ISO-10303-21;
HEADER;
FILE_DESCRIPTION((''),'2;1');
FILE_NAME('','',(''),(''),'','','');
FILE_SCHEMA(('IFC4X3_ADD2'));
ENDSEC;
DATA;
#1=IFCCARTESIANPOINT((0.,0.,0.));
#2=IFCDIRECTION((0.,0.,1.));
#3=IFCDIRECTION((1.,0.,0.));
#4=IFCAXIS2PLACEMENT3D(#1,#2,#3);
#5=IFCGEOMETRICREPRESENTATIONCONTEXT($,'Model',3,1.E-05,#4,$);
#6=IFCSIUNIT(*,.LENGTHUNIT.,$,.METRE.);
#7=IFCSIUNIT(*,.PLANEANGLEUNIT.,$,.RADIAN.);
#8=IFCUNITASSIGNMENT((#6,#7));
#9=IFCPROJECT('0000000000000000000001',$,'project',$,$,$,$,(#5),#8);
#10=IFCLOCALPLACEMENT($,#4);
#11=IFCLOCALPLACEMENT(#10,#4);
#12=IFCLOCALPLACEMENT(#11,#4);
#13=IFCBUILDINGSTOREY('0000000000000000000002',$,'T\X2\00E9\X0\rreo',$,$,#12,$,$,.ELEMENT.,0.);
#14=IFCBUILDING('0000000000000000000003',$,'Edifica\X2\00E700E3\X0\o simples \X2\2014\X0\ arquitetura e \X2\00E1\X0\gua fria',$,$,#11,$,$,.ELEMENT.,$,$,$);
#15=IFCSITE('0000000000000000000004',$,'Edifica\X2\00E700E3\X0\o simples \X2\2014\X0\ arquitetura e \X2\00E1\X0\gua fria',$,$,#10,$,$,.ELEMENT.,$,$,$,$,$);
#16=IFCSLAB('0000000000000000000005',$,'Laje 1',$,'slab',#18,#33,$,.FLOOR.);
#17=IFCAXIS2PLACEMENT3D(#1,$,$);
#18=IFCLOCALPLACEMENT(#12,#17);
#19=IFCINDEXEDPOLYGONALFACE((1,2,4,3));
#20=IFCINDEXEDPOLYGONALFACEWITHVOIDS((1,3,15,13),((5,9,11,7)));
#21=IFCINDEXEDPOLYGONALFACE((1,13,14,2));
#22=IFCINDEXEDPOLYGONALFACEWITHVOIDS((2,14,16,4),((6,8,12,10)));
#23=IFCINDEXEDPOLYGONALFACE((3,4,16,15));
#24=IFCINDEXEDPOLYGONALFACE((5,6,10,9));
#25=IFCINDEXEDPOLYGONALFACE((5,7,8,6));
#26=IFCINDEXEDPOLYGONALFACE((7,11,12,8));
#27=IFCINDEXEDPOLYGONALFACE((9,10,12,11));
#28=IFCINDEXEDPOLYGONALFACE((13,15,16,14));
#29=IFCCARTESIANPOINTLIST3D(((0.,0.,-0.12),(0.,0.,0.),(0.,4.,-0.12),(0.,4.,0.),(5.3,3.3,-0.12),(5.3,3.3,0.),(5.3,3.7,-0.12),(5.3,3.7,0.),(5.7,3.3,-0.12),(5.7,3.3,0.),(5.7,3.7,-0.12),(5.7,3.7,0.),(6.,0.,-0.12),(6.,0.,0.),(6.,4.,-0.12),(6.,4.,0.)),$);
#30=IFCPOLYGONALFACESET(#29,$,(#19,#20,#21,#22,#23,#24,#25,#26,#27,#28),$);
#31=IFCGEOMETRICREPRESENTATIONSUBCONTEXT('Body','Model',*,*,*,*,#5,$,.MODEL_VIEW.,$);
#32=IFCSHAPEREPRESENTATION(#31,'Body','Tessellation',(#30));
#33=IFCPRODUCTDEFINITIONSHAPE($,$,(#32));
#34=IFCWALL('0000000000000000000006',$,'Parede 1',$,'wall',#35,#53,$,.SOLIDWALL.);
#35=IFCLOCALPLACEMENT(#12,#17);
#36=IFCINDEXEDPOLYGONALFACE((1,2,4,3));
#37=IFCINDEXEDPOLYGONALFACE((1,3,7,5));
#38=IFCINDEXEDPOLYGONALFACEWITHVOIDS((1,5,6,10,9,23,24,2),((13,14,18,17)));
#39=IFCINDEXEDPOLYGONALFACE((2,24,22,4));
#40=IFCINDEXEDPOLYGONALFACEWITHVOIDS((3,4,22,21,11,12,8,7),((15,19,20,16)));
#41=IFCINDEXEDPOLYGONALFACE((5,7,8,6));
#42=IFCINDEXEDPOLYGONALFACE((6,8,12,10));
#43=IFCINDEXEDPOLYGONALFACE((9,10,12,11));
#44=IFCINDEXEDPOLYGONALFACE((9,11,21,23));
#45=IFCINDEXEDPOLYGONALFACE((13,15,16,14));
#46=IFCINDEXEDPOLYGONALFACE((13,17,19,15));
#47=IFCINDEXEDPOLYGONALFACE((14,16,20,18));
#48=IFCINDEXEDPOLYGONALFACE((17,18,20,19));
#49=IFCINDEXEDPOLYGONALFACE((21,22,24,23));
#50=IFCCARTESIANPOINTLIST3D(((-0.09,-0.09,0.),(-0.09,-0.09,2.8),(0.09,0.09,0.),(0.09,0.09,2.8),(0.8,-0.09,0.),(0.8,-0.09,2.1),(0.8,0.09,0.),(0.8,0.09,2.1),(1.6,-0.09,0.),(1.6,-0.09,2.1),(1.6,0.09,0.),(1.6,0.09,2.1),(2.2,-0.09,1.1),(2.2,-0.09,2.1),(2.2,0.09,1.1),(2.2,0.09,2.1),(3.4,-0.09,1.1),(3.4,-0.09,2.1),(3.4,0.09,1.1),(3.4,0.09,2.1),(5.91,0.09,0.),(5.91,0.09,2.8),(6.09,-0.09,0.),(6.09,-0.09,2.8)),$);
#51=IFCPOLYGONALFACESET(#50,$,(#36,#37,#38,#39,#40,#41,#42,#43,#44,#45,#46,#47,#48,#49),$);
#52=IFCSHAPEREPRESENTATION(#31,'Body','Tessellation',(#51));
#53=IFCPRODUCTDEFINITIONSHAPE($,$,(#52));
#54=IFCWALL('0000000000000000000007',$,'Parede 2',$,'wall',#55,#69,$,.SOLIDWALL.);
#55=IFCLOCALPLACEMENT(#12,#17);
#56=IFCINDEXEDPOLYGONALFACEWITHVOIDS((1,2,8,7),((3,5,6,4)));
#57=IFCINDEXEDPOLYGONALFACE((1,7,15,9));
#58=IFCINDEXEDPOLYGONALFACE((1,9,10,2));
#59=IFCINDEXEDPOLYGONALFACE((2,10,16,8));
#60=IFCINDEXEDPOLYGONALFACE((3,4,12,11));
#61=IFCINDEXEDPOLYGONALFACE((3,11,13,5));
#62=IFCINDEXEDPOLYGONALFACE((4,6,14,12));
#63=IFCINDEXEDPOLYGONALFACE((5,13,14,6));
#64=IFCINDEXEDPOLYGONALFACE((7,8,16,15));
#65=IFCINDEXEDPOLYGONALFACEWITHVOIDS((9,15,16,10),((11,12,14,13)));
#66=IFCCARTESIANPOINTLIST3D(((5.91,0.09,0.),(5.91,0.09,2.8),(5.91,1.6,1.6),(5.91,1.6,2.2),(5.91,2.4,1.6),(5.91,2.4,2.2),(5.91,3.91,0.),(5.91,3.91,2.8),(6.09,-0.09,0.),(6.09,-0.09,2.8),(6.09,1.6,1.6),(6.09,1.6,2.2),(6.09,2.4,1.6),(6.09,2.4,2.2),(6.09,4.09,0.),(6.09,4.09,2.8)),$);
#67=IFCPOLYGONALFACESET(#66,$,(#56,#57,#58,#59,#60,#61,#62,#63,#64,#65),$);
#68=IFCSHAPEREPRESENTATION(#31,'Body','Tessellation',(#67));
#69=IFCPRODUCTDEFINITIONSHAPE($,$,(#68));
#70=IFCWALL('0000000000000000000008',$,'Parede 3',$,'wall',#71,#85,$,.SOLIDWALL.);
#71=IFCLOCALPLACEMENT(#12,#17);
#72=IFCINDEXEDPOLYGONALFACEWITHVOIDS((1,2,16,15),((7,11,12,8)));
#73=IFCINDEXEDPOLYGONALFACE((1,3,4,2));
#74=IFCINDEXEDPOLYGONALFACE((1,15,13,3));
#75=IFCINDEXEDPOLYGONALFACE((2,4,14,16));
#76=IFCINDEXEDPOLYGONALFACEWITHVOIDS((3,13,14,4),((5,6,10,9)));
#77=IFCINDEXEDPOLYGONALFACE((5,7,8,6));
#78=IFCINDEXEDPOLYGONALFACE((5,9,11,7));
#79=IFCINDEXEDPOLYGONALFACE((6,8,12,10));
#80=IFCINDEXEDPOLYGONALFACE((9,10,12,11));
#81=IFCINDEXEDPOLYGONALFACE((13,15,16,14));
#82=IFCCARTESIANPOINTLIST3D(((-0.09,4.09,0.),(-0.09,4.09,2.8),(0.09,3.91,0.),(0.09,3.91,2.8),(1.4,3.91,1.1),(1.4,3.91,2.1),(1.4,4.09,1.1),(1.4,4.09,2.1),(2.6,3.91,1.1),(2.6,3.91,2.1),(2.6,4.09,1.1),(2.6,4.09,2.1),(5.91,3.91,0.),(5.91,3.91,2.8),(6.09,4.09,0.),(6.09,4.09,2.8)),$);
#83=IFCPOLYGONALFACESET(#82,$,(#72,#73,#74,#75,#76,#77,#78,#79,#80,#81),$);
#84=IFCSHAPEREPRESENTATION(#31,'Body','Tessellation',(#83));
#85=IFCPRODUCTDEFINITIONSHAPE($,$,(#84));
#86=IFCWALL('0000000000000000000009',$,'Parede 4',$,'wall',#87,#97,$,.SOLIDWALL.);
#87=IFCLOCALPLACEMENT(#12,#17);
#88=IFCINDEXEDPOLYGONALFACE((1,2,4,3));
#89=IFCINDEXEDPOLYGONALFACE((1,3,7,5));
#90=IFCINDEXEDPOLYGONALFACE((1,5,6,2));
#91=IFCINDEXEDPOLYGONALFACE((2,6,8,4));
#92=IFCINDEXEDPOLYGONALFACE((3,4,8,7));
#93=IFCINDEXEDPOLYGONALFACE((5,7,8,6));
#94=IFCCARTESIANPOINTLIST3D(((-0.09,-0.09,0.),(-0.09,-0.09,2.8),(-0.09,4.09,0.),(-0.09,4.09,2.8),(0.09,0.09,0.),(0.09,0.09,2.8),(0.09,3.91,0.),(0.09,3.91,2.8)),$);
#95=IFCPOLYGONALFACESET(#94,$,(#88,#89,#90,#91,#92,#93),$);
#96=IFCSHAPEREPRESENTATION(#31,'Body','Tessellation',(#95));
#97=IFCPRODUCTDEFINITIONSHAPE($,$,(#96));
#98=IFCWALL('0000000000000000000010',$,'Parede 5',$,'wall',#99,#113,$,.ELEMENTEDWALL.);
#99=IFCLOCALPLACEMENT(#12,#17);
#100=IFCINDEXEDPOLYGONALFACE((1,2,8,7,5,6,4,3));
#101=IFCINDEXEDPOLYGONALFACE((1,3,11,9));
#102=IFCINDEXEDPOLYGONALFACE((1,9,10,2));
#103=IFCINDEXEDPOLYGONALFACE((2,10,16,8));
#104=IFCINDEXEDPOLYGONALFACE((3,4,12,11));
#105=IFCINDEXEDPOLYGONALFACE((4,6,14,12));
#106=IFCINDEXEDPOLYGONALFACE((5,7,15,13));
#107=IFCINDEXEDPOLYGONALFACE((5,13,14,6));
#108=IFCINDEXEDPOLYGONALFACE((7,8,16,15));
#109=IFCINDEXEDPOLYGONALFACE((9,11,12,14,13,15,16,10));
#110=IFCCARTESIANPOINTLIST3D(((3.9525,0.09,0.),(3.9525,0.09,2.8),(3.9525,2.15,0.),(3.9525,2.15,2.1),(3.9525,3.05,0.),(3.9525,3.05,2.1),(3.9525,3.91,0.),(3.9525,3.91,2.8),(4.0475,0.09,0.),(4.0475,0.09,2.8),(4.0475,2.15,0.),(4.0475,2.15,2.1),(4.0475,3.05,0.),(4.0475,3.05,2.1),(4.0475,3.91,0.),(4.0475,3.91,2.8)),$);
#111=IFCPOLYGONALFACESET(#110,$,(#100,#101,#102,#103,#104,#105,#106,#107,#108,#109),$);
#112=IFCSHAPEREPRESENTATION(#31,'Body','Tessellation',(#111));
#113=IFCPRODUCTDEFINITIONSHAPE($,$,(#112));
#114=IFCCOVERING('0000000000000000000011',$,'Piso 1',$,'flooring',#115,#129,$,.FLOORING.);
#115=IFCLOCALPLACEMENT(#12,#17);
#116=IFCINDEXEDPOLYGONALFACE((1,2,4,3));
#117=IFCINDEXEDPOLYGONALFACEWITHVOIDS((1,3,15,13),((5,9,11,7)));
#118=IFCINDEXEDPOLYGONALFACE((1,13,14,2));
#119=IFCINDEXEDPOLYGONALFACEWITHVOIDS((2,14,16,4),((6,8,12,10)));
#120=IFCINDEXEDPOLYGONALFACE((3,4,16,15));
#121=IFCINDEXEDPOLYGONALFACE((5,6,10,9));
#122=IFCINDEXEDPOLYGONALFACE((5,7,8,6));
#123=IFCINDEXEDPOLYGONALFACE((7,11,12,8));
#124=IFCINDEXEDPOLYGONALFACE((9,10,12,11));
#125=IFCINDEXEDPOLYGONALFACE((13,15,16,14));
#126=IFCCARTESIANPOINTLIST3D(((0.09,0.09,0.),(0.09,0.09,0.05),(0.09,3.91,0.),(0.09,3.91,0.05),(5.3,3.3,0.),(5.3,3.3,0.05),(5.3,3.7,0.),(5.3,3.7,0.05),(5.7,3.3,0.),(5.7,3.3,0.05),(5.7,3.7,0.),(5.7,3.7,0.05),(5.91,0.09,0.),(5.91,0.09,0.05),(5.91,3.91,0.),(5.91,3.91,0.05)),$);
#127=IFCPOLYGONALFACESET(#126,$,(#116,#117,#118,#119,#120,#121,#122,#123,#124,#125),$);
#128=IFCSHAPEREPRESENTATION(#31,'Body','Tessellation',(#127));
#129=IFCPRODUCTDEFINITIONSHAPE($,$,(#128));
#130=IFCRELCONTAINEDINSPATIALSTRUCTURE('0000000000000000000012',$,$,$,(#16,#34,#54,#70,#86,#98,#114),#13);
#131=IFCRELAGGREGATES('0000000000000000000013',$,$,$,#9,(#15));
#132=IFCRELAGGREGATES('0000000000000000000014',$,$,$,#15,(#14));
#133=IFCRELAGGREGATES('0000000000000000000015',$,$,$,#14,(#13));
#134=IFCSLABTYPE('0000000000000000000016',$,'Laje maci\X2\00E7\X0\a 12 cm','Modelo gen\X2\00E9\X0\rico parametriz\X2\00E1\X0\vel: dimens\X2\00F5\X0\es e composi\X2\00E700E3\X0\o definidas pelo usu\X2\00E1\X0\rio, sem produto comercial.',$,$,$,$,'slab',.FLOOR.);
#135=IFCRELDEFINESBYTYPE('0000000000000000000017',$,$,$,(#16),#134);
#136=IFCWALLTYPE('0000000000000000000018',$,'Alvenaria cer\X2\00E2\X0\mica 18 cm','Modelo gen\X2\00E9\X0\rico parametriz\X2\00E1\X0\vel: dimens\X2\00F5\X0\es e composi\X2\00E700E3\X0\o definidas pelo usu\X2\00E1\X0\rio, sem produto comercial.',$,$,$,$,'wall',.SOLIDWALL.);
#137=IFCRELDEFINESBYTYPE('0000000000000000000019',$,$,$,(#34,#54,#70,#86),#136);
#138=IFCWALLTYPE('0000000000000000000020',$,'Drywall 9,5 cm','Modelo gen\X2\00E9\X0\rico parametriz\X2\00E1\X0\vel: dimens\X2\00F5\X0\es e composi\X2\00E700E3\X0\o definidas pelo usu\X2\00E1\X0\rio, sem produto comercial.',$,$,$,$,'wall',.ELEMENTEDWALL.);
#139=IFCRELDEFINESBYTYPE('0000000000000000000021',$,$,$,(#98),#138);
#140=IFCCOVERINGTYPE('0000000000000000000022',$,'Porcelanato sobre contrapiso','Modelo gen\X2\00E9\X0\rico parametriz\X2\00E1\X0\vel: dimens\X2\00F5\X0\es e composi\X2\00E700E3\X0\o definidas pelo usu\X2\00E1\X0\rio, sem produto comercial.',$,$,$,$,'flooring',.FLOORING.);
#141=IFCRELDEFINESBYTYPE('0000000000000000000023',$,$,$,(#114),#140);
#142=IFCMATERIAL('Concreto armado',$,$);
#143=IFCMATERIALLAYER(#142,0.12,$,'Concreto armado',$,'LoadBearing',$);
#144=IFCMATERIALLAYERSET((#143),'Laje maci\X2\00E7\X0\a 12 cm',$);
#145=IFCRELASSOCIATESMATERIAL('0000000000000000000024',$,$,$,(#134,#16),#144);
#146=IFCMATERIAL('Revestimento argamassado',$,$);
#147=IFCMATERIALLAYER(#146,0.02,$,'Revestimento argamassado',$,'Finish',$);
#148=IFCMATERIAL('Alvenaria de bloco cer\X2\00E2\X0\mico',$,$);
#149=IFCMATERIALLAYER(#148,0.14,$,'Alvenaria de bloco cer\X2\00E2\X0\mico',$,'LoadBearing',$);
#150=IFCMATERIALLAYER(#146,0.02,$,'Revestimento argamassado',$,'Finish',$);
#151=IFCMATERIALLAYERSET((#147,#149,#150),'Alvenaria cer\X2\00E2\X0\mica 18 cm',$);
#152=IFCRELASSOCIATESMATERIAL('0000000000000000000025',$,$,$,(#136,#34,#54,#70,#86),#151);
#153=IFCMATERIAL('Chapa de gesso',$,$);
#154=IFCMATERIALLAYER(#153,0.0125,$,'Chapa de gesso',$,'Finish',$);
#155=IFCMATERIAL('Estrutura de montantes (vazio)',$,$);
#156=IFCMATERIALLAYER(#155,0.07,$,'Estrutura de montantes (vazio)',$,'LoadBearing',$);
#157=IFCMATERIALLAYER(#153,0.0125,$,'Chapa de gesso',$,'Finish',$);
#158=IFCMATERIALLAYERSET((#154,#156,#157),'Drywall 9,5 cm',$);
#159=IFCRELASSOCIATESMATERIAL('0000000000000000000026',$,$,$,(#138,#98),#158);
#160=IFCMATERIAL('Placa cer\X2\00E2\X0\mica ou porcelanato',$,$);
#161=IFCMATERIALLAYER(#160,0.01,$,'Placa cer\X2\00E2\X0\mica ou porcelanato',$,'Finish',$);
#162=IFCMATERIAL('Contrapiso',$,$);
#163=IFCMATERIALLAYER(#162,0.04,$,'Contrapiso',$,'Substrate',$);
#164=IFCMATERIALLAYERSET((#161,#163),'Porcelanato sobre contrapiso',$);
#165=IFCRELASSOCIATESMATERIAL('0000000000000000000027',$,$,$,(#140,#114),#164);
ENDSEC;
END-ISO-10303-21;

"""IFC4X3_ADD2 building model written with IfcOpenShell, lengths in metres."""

from ifc_helpers import new_model, si_unit, frame, origin, origin_with_axes, place, context, subcontext, project, spatial, polyline, rectangle, outline, extrude, material, layer, layer_set, layer_usage, type_object, element, save


model = new_model("IFC4X3_ADD2")

# Units and contexts
model_context = context("Model", 3, precision=1e-05, world=origin_with_axes())
body_context = subcontext(model_context, "Body", "Model", "MODEL_VIEW")
ifc_project = project(units=[si_unit("LENGTHUNIT", "METRE"), si_unit("PLANEANGLEUNIT", "RADIAN")], contexts=[model_context])

# Site, building, storey
site_placement = place(None, origin_with_axes())
site = spatial("IfcSite", under=ifc_project, at=site_placement, Name="Edificação simples — arquitetura e água fria", CompositionType="ELEMENT")
building_placement = place(site_placement, origin_with_axes())
building = spatial("IfcBuilding", under=site, at=building_placement, Name="Edificação simples — arquitetura e água fria", CompositionType="ELEMENT")
storey_placement = place(building_placement, origin_with_axes())
storey = spatial("IfcBuildingStorey", under=building, at=storey_placement, Name="Térreo", CompositionType="ELEMENT", Elevation=0.0)

# Slab, opening
ifc_material_1 = material(Name="Concreto armado")
ifc_layer_1 = layer(ifc_material_1, 0.12, Name="Concreto armado", Category="LoadBearing")
ifc_layer_set_1 = layer_set([ifc_layer_1], Name="Laje maciça 12 cm")
ifc_layer_usage_1 = layer_usage(ifc_layer_set_1, "AXIS3", "NEGATIVE", 0.0)
slab_type = type_object("IfcSlabType", Name="Laje maciça 12 cm", Description="Modelo genérico parametrizável: dimensões e composição definidas pelo usuário, sem produto comercial.", ElementType="slab", PredefinedType="FLOOR", material=ifc_layer_set_1)
slab_placement = place(storey_placement, origin_with_axes())
slab = element("IfcSlab", 1, at=slab_placement, inside=storey, type_object=slab_type, material=ifc_layer_usage_1, Name="Laje 1", ObjectType="slab", PredefinedType="FLOOR", context=body_context, shape_type="SweptSolid", body=[
    extrude(outline(polyline([(0.0, 0.0), (6.0, 0.0), (6.0, 4.0), (0.0, 4.0), (0.0, 0.0)])), origin(), (0.0, 0.0, -1.0), 0.12),
])
opening_1_placement = place(slab_placement, origin_with_axes())
element("IfcOpeningElement", 2, at=opening_1_placement, cuts=slab, PredefinedType="OPENING", context=body_context, shape_type="SweptSolid", body=[
    extrude(outline(polyline([(5.3, 3.7), (5.7, 3.7), (5.7, 3.3), (5.3, 3.3), (5.3, 3.7)])), frame((0.0, 0.0, 0.005)), (0.0, 0.0, -1.0), 0.13),
])

# Wall, openings
ifc_material_2 = material(Name="Revestimento argamassado")
ifc_layer_2 = layer(ifc_material_2, 0.02, Name="Revestimento argamassado", Category="Finish")
ifc_material_3 = material(Name="Alvenaria de bloco cerâmico")
ifc_layer_3 = layer(ifc_material_3, 0.14, Name="Alvenaria de bloco cerâmico", Category="LoadBearing")
ifc_layer_4 = layer(ifc_material_2, 0.02, Name="Revestimento argamassado", Category="Finish")
ifc_layer_set_2 = layer_set([ifc_layer_2, ifc_layer_3, ifc_layer_4], Name="Alvenaria cerâmica 18 cm")
ifc_layer_usage_2 = layer_usage(ifc_layer_set_2, "AXIS2", "NEGATIVE", 0.09)
wall_type_1 = type_object("IfcWallType", Name="Alvenaria cerâmica 18 cm", Description="Modelo genérico parametrizável: dimensões e composição definidas pelo usuário, sem produto comercial.", ElementType="wall", PredefinedType="SOLIDWALL", material=ifc_layer_set_2)
wall_1_placement = place(storey_placement, origin_with_axes())
wall_1 = element("IfcWall", 3, at=wall_1_placement, inside=storey, type_object=wall_type_1, material=ifc_layer_usage_2, Name="Parede 1", ObjectType="wall", PredefinedType="SOLIDWALL", context=body_context, shape_type="SweptSolid", body=[
    extrude(outline(polyline([(0.09, 0.09), (-0.09, -0.09), (6.09, -0.09), (5.91, 0.09), (0.09, 0.09)])), origin(), (0.0, 0.0, 1.0), 2.8),
])
opening_2_placement = place(wall_1_placement, origin_with_axes())
element("IfcOpeningElement", 4, at=opening_2_placement, cuts=wall_1, PredefinedType="OPENING", context=body_context, shape_type="SweptSolid", body=[
    extrude(rectangle(XDim=0.8, YDim=0.19), frame((1.2, 0.0, 0.0)), (0.0, 0.0, 1.0), 2.1),
])
opening_3_placement = place(wall_1_placement, origin_with_axes())
element("IfcOpeningElement", 5, at=opening_3_placement, cuts=wall_1, PredefinedType="OPENING", context=body_context, shape_type="SweptSolid", body=[
    extrude(rectangle(XDim=1.2, YDim=0.19), frame((2.8, 0.0, 1.1)), (0.0, 0.0, 1.0), 1.0),
])

# Walls, openings
ifc_layer_usage_3 = layer_usage(ifc_layer_set_2, "AXIS2", "NEGATIVE", 0.09)
wall_2_placement = place(storey_placement, frame((6.0, 0.0, 0.0), z_axis=(0.0, 0.0, 1.0), x_axis=(0.0, 1.0, 0.0)))
wall_2 = element("IfcWall", 6, at=wall_2_placement, inside=storey, type_object=wall_type_1, material=ifc_layer_usage_3, Name="Parede 2", ObjectType="wall", PredefinedType="SOLIDWALL", context=body_context, shape_type="SweptSolid", body=[
    extrude(outline(polyline([(0.09, 0.09), (-0.09, -0.09), (4.09, -0.09), (3.91, 0.09), (0.09, 0.09)])), origin(), (0.0, 0.0, 1.0), 2.8),
])
opening_4_placement = place(wall_2_placement, origin_with_axes())
element("IfcOpeningElement", 7, at=opening_4_placement, cuts=wall_2, PredefinedType="OPENING", context=body_context, shape_type="SweptSolid", body=[
    extrude(rectangle(XDim=0.8, YDim=0.19), frame((2.0, 0.0, 1.6)), (0.0, 0.0, 1.0), 0.6),
])
ifc_layer_usage_4 = layer_usage(ifc_layer_set_2, "AXIS2", "NEGATIVE", 0.09)
wall_3_placement = place(storey_placement, frame((6.0, 4.0, 0.0), z_axis=(0.0, 0.0, 1.0), x_axis=(-1.0, 0.0, 0.0)))
wall_3 = element("IfcWall", 8, at=wall_3_placement, inside=storey, type_object=wall_type_1, material=ifc_layer_usage_4, Name="Parede 3", ObjectType="wall", PredefinedType="SOLIDWALL", context=body_context, shape_type="SweptSolid", body=[
    extrude(outline(polyline([(0.09, 0.09), (-0.09, -0.09), (6.09, -0.09), (5.91, 0.09), (0.09, 0.09)])), origin(), (0.0, 0.0, 1.0), 2.8),
])
opening_5_placement = place(wall_3_placement, origin_with_axes())
element("IfcOpeningElement", 9, at=opening_5_placement, cuts=wall_3, PredefinedType="OPENING", context=body_context, shape_type="SweptSolid", body=[
    extrude(rectangle(XDim=1.2, YDim=0.19), frame((4.0, 0.0, 1.1)), (0.0, 0.0, 1.0), 1.0),
])

# Wall
ifc_layer_usage_5 = layer_usage(ifc_layer_set_2, "AXIS2", "NEGATIVE", 0.09)
wall_4_placement = place(storey_placement, frame((0.0, 4.0, 0.0), z_axis=(0.0, 0.0, 1.0), x_axis=(0.0, -1.0, 0.0)))
element("IfcWall", 10, at=wall_4_placement, inside=storey, type_object=wall_type_1, material=ifc_layer_usage_5, Name="Parede 4", ObjectType="wall", PredefinedType="SOLIDWALL", context=body_context, shape_type="SweptSolid", body=[
    extrude(outline(polyline([(0.09, 0.09), (-0.09, -0.09), (4.09, -0.09), (3.91, 0.09), (0.09, 0.09)])), origin(), (0.0, 0.0, 1.0), 2.8),
])

# Wall, opening
ifc_material_4 = material(Name="Chapa de gesso")
ifc_layer_5 = layer(ifc_material_4, 0.0125, Name="Chapa de gesso", Category="Finish")
ifc_material_5 = material(Name="Estrutura de montantes (vazio)")
ifc_layer_6 = layer(ifc_material_5, 0.07, Name="Estrutura de montantes (vazio)", Category="LoadBearing")
ifc_layer_7 = layer(ifc_material_4, 0.0125, Name="Chapa de gesso", Category="Finish")
ifc_layer_set_3 = layer_set([ifc_layer_5, ifc_layer_6, ifc_layer_7], Name="Drywall 9,5 cm")
ifc_layer_usage_6 = layer_usage(ifc_layer_set_3, "AXIS2", "NEGATIVE", 0.0475)
wall_type_2 = type_object("IfcWallType", Name="Drywall 9,5 cm", Description="Modelo genérico parametrizável: dimensões e composição definidas pelo usuário, sem produto comercial.", ElementType="wall", PredefinedType="ELEMENTEDWALL", material=ifc_layer_set_3)
wall_5_placement = place(storey_placement, frame((4.0, 0.0, 0.0), z_axis=(0.0, 0.0, 1.0), x_axis=(0.0, 1.0, 0.0)))
wall_5 = element("IfcWall", 11, at=wall_5_placement, inside=storey, type_object=wall_type_2, material=ifc_layer_usage_6, Name="Parede 5", ObjectType="wall", PredefinedType="ELEMENTEDWALL", context=body_context, shape_type="SweptSolid", body=[
    extrude(outline(polyline([(0.09, 0.0475), (0.09, -0.0475), (3.91, -0.0475), (3.91, 0.0475), (0.09, 0.0475)])), origin(), (0.0, 0.0, 1.0), 2.8),
])
opening_6_placement = place(wall_5_placement, origin_with_axes())
element("IfcOpeningElement", 12, at=opening_6_placement, cuts=wall_5, PredefinedType="OPENING", context=body_context, shape_type="SweptSolid", body=[
    extrude(rectangle(XDim=0.9, YDim=0.105), frame((2.6, 0.0, 0.0)), (0.0, 0.0, 1.0), 2.1),
])

# Covering, opening
ifc_material_6 = material(Name="Placa cerâmica ou porcelanato")
ifc_layer_8 = layer(ifc_material_6, 0.01, Name="Placa cerâmica ou porcelanato", Category="Finish")
ifc_material_7 = material(Name="Contrapiso")
ifc_layer_9 = layer(ifc_material_7, 0.04, Name="Contrapiso", Category="Substrate")
ifc_layer_set_4 = layer_set([ifc_layer_8, ifc_layer_9], Name="Porcelanato sobre contrapiso")
ifc_layer_usage_7 = layer_usage(ifc_layer_set_4, "AXIS3", "NEGATIVE", 0.05)
covering_type = type_object("IfcCoveringType", Name="Porcelanato sobre contrapiso", Description="Modelo genérico parametrizável: dimensões e composição definidas pelo usuário, sem produto comercial.", ElementType="flooring", PredefinedType="FLOORING", material=ifc_layer_set_4)
covering_placement = place(storey_placement, frame((0.09, 0.09, 0.0), z_axis=(0.0, 0.0, 1.0), x_axis=(1.0, 0.0, 0.0)))
covering = element("IfcCovering", 13, at=covering_placement, inside=storey, type_object=covering_type, material=ifc_layer_usage_7, Name="Piso 1", ObjectType="flooring", PredefinedType="FLOORING", context=body_context, shape_type="SweptSolid", body=[
    extrude(outline(polyline([(0.0, 0.0), (5.82, 0.0), (5.82, 3.82), (0.0, 3.82), (0.0, 0.0)])), origin(), (0.0, 0.0, 1.0), 0.05),
])
opening_7_placement = place(covering_placement, origin_with_axes())
element("IfcOpeningElement", 14, at=opening_7_placement, cuts=covering, PredefinedType="OPENING", context=body_context, shape_type="SweptSolid", body=[
    extrude(outline(polyline([(5.21, 3.61), (5.61, 3.61), (5.61, 3.21), (5.21, 3.21), (5.21, 3.61)])), frame((0.0, 0.0, -0.005)), (0.0, 0.0, 1.0), 0.06),
])

save(model, "model.ifc")
